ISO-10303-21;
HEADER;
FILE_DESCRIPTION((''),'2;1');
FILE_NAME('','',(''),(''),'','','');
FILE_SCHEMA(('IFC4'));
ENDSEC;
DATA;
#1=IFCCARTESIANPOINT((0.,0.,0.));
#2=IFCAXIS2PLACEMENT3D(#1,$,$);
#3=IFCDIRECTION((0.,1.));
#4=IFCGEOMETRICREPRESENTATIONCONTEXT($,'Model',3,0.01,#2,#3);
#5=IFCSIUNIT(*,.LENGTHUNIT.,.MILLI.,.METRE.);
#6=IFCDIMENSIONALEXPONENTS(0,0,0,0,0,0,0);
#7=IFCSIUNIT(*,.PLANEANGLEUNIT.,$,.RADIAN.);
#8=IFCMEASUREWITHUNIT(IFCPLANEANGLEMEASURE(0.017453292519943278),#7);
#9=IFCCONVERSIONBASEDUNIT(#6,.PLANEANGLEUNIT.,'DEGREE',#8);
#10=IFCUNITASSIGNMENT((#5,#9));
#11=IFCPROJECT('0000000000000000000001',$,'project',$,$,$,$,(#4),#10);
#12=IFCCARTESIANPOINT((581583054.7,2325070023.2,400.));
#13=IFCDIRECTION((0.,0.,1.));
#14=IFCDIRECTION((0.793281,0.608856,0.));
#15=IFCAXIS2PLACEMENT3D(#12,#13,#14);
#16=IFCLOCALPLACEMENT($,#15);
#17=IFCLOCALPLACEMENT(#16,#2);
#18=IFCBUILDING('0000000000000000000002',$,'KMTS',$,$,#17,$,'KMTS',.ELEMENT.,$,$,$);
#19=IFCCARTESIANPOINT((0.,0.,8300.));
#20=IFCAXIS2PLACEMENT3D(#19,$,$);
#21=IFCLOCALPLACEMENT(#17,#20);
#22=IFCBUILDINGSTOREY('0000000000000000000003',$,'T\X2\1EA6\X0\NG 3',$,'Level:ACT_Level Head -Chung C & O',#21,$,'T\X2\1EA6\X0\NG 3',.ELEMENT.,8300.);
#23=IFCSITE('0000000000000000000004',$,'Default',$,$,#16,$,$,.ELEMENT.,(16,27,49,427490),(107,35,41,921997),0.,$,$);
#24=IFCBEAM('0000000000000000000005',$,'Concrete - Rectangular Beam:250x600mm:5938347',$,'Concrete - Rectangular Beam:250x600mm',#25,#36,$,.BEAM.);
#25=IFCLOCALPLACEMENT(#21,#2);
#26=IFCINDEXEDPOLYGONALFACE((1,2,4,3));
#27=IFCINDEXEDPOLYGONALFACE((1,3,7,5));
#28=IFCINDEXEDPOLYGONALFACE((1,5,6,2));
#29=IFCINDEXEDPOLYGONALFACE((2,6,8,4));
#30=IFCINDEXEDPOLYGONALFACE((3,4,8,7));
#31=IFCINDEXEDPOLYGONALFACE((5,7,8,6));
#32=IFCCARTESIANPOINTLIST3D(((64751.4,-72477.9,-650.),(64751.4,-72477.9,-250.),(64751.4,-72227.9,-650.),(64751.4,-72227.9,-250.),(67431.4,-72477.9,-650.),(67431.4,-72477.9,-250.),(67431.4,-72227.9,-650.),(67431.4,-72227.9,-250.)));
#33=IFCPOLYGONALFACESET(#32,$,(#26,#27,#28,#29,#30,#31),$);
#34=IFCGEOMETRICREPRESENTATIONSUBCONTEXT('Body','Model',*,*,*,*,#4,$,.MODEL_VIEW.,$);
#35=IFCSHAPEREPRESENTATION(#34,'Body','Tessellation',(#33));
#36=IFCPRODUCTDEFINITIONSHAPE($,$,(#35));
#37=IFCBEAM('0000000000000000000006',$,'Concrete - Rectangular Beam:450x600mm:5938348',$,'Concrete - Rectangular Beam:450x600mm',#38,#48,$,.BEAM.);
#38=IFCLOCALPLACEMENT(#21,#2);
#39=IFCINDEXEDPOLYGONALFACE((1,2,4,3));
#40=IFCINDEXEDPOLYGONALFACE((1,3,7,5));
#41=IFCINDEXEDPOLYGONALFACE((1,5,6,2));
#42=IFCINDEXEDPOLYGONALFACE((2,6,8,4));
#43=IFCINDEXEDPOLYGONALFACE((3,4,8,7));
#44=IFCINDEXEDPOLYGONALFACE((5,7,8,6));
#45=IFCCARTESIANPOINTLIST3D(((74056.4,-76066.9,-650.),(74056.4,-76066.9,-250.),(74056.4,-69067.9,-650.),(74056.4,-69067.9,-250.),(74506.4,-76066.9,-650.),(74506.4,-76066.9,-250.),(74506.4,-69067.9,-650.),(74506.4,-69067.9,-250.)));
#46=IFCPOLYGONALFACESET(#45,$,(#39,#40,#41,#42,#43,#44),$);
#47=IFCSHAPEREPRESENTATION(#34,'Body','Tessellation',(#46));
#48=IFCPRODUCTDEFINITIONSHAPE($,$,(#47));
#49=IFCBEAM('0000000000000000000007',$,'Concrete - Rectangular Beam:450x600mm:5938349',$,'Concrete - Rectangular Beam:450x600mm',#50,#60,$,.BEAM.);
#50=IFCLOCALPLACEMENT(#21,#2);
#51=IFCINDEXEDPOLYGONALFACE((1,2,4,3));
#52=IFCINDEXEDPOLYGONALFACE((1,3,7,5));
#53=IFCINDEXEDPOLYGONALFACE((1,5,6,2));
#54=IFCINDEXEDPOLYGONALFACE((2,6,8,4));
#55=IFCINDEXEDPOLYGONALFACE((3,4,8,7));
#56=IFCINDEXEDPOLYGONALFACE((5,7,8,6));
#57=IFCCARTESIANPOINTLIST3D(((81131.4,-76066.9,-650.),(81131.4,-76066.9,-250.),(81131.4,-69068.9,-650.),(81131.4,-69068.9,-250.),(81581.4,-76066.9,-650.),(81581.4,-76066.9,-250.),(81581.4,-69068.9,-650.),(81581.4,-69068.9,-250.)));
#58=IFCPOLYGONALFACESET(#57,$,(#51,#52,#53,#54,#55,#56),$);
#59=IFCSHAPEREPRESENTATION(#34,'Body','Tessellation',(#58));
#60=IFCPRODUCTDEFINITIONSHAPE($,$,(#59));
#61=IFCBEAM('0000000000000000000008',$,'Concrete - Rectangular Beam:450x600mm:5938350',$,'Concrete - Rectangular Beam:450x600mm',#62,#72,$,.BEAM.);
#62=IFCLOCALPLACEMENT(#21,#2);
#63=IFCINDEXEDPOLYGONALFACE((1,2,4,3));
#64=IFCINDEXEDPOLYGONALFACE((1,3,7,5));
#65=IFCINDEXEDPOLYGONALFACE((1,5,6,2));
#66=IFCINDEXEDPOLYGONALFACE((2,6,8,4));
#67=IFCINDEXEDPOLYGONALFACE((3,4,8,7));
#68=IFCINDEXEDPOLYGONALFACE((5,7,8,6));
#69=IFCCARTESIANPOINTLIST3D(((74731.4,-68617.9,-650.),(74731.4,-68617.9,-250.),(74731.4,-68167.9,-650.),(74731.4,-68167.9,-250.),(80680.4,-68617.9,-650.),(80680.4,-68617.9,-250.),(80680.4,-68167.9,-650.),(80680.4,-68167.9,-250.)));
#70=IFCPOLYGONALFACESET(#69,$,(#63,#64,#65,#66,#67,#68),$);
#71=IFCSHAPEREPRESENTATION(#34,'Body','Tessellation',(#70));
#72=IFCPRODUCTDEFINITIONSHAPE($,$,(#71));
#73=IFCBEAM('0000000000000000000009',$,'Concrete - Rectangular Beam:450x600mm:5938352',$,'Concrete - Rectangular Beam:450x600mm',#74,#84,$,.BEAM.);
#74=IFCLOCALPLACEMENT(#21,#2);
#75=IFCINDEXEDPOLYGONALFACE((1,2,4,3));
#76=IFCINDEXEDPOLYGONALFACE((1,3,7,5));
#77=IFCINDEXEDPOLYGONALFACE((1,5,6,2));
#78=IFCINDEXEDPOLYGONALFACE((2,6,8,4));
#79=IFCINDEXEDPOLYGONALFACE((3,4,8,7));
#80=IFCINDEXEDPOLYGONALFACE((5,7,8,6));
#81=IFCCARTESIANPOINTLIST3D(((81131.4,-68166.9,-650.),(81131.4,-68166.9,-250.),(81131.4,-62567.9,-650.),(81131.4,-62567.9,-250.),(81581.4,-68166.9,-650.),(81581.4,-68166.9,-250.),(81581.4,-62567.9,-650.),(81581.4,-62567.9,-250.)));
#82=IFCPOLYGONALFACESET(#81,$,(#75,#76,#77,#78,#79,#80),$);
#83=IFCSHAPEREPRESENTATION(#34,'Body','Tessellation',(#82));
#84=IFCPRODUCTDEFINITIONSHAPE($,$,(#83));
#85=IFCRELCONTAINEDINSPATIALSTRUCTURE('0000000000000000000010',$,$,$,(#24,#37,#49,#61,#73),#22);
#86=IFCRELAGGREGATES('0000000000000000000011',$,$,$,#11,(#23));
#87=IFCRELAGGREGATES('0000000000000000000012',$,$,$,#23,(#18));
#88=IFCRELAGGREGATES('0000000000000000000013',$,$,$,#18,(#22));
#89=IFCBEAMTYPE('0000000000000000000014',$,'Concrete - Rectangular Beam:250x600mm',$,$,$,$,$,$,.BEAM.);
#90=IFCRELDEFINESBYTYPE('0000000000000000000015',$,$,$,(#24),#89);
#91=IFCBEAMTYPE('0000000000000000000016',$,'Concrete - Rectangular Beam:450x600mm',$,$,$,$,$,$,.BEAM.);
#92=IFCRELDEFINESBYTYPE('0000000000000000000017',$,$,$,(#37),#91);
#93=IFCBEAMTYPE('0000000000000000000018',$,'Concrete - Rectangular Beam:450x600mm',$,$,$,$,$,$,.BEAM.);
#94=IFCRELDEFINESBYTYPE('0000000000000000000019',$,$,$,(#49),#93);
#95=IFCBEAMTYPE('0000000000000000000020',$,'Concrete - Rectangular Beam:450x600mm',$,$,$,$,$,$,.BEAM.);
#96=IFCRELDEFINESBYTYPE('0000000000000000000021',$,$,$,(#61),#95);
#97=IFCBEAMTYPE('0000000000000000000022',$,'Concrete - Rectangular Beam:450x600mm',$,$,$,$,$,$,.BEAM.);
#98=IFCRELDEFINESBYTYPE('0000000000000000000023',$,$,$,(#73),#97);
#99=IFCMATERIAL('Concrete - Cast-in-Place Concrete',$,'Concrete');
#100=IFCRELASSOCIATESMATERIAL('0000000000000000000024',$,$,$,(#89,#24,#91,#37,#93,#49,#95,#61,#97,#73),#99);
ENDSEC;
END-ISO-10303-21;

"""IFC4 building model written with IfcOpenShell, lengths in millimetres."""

from ifc_helpers import new_model, entity, si_unit, converted_unit, direction, frame, origin, place, context, subcontext, project, spatial, indexed_curve, outline, extrude, source, transform, mapped, material, type_object, type_shapes, element, save


model = new_model("IFC4")

# Units and contexts
model_context = context("Model", 3, precision=0.01, world=origin(), true_north=direction((0.0, 1.0)))
body_context = subcontext(model_context, "Body", "Model", "MODEL_VIEW")
ifc_project = project(units=[si_unit("LENGTHUNIT", "METRE", prefix="MILLI"), converted_unit("PLANEANGLEUNIT", "DEGREE", entity("IfcPlaneAngleMeasure", 0.017453292519943278), si_unit("PLANEANGLEUNIT", "RADIAN"), dimensions=[0, 0, 0, 0, 0, 0, 0])], contexts=[model_context])

# Site, building, storey
site_placement = place(None, frame((581583054.7, 2325070023.2, 400.0), z_axis=(0.0, 0.0, 1.0), x_axis=(0.793281, 0.608856, 0.0)))
site = spatial("IfcSite", under=ifc_project, at=site_placement, Name="Default", CompositionType="ELEMENT", RefLatitude=(16, 27, 49, 427490), RefLongitude=(107, 35, 41, 921997), RefElevation=0.0)
building_placement = place(site_placement, origin())
building = spatial("IfcBuilding", under=site, at=building_placement, Name="KMTS", LongName="KMTS", CompositionType="ELEMENT")
storey_placement = place(building_placement, frame((0.0, 0.0, 8300.0)))
storey = spatial("IfcBuildingStorey", under=building, at=storey_placement, Name="TẦNG 3", ObjectType="Level:ACT_Level Head -Chung C & O", LongName="TẦNG 3", CompositionType="ELEMENT", Elevation=8300.0)

# Beams
ifc_material_1 = material(Name="Concrete - Cast-in-Place Concrete", Category="Concrete")
beam_type_1 = type_object("IfcBeamType", Name="Concrete - Rectangular Beam:250x600mm", PredefinedType="BEAM", material=ifc_material_1)
shared_shape_1 = source(origin(), body_context, "Body", "SweptSolid", [
    extrude(outline(indexed_curve([(-200.0, -125.0), (200.0, -125.0), (200.0, 125.0), (-200.0, 125.0), (-200.0, -125.0)], self_intersect=False)), frame((64751.4, -72352.9, 7850.0), z_axis=(1.0, 0.0, 0.0), x_axis=(0.0, 0.0, -1.0)), (0.0, 0.0, 1.0), 2680.0),
])
type_shapes(beam_type_1, [shared_shape_1])
beam_1_placement = place(storey_placement, frame((0.0, 0.0, -8300.0)))
element("IfcBeam", 1, at=beam_1_placement, inside=storey, type_object=beam_type_1, material=ifc_material_1, Name="Concrete - Rectangular Beam:250x600mm:5938347", ObjectType="Concrete - Rectangular Beam:250x600mm", PredefinedType="BEAM", context=body_context, shape_type="MappedRepresentation", body=[
    mapped(shared_shape_1, transform((0.0, 0.0, 0.0), scale=1.0)),
])
beam_type_2 = type_object("IfcBeamType", Name="Concrete - Rectangular Beam:450x600mm", PredefinedType="BEAM", material=ifc_material_1)
shared_shape_2 = source(origin(), body_context, "Body", "SweptSolid", [
    extrude(outline(indexed_curve([(-225.0, -200.0), (225.0, -200.0), (225.0, 200.0), (-225.0, 200.0), (-225.0, -200.0)], self_intersect=False)), frame((74281.4, -76066.9, 7850.0), z_axis=(0.0, 1.0, 0.0), x_axis=(-1.0, 0.0, 0.0)), (0.0, 0.0, 1.0), 6999.0),
])
type_shapes(beam_type_2, [shared_shape_2])
beam_2_placement = place(storey_placement, frame((0.0, 0.0, -8300.0)))
element("IfcBeam", 2, at=beam_2_placement, inside=storey, type_object=beam_type_2, material=ifc_material_1, Name="Concrete - Rectangular Beam:450x600mm:5938348", ObjectType="Concrete - Rectangular Beam:450x600mm", PredefinedType="BEAM", context=body_context, shape_type="MappedRepresentation", body=[
    mapped(shared_shape_2, transform((0.0, 0.0, 0.0), scale=1.0)),
])
beam_type_3 = type_object("IfcBeamType", Name="Concrete - Rectangular Beam:450x600mm", PredefinedType="BEAM", material=ifc_material_1)
shared_shape_3 = source(origin(), body_context, "Body", "SweptSolid", [
    extrude(outline(indexed_curve([(-225.0, -200.0), (225.0, -200.0), (225.0, 200.0), (-225.0, 200.0), (-225.0, -200.0)], self_intersect=False)), frame((81356.4, -76066.9, 7850.0), z_axis=(0.0, 1.0, 0.0), x_axis=(-1.0, 0.0, 0.0)), (0.0, 0.0, 1.0), 6998.0),
])
type_shapes(beam_type_3, [shared_shape_3])
beam_3_placement = place(storey_placement, frame((0.0, 0.0, -8300.0)))
element("IfcBeam", 3, at=beam_3_placement, inside=storey, type_object=beam_type_3, material=ifc_material_1, Name="Concrete - Rectangular Beam:450x600mm:5938349", ObjectType="Concrete - Rectangular Beam:450x600mm", PredefinedType="BEAM", context=body_context, shape_type="MappedRepresentation", body=[
    mapped(shared_shape_3, transform((0.0, 0.0, 0.0), scale=1.0)),
])
beam_type_4 = type_object("IfcBeamType", Name="Concrete - Rectangular Beam:450x600mm", PredefinedType="BEAM", material=ifc_material_1)
shared_shape_4 = source(origin(), body_context, "Body", "SweptSolid", [
    extrude(outline(indexed_curve([(-200.0, -225.0), (200.0, -225.0), (200.0, 225.0), (-200.0, 225.0), (-200.0, -225.0)], self_intersect=False)), frame((74731.4, -68392.9, 7850.0), z_axis=(1.0, 0.0, 0.0), x_axis=(0.0, 0.0, -1.0)), (0.0, 0.0, 1.0), 5949.0),
])
type_shapes(beam_type_4, [shared_shape_4])
beam_4_placement = place(storey_placement, frame((0.0, 0.0, -8300.0)))
element("IfcBeam", 4, at=beam_4_placement, inside=storey, type_object=beam_type_4, material=ifc_material_1, Name="Concrete - Rectangular Beam:450x600mm:5938350", ObjectType="Concrete - Rectangular Beam:450x600mm", PredefinedType="BEAM", context=body_context, shape_type="MappedRepresentation", body=[
    mapped(shared_shape_4, transform((0.0, 0.0, 0.0), scale=1.0)),
])
beam_type_5 = type_object("IfcBeamType", Name="Concrete - Rectangular Beam:450x600mm", PredefinedType="BEAM", material=ifc_material_1)
shared_shape_5 = source(origin(), body_context, "Body", "SweptSolid", [
    extrude(outline(indexed_curve([(-225.0, -200.0), (225.0, -200.0), (225.0, 200.0), (-225.0, 200.0), (-225.0, -200.0)], self_intersect=False)), frame((81356.4, -68166.9, 7850.0), z_axis=(0.0, 1.0, 0.0), x_axis=(-1.0, 0.0, 0.0)), (0.0, 0.0, 1.0), 5599.0),
])
type_shapes(beam_type_5, [shared_shape_5])
beam_5_placement = place(storey_placement, frame((0.0, 0.0, -8300.0)))
element("IfcBeam", 5, at=beam_5_placement, inside=storey, type_object=beam_type_5, material=ifc_material_1, Name="Concrete - Rectangular Beam:450x600mm:5938352", ObjectType="Concrete - Rectangular Beam:450x600mm", PredefinedType="BEAM", context=body_context, shape_type="MappedRepresentation", body=[
    mapped(shared_shape_5, transform((0.0, 0.0, 0.0), scale=1.0)),
])

save(model, "model.ifc")
